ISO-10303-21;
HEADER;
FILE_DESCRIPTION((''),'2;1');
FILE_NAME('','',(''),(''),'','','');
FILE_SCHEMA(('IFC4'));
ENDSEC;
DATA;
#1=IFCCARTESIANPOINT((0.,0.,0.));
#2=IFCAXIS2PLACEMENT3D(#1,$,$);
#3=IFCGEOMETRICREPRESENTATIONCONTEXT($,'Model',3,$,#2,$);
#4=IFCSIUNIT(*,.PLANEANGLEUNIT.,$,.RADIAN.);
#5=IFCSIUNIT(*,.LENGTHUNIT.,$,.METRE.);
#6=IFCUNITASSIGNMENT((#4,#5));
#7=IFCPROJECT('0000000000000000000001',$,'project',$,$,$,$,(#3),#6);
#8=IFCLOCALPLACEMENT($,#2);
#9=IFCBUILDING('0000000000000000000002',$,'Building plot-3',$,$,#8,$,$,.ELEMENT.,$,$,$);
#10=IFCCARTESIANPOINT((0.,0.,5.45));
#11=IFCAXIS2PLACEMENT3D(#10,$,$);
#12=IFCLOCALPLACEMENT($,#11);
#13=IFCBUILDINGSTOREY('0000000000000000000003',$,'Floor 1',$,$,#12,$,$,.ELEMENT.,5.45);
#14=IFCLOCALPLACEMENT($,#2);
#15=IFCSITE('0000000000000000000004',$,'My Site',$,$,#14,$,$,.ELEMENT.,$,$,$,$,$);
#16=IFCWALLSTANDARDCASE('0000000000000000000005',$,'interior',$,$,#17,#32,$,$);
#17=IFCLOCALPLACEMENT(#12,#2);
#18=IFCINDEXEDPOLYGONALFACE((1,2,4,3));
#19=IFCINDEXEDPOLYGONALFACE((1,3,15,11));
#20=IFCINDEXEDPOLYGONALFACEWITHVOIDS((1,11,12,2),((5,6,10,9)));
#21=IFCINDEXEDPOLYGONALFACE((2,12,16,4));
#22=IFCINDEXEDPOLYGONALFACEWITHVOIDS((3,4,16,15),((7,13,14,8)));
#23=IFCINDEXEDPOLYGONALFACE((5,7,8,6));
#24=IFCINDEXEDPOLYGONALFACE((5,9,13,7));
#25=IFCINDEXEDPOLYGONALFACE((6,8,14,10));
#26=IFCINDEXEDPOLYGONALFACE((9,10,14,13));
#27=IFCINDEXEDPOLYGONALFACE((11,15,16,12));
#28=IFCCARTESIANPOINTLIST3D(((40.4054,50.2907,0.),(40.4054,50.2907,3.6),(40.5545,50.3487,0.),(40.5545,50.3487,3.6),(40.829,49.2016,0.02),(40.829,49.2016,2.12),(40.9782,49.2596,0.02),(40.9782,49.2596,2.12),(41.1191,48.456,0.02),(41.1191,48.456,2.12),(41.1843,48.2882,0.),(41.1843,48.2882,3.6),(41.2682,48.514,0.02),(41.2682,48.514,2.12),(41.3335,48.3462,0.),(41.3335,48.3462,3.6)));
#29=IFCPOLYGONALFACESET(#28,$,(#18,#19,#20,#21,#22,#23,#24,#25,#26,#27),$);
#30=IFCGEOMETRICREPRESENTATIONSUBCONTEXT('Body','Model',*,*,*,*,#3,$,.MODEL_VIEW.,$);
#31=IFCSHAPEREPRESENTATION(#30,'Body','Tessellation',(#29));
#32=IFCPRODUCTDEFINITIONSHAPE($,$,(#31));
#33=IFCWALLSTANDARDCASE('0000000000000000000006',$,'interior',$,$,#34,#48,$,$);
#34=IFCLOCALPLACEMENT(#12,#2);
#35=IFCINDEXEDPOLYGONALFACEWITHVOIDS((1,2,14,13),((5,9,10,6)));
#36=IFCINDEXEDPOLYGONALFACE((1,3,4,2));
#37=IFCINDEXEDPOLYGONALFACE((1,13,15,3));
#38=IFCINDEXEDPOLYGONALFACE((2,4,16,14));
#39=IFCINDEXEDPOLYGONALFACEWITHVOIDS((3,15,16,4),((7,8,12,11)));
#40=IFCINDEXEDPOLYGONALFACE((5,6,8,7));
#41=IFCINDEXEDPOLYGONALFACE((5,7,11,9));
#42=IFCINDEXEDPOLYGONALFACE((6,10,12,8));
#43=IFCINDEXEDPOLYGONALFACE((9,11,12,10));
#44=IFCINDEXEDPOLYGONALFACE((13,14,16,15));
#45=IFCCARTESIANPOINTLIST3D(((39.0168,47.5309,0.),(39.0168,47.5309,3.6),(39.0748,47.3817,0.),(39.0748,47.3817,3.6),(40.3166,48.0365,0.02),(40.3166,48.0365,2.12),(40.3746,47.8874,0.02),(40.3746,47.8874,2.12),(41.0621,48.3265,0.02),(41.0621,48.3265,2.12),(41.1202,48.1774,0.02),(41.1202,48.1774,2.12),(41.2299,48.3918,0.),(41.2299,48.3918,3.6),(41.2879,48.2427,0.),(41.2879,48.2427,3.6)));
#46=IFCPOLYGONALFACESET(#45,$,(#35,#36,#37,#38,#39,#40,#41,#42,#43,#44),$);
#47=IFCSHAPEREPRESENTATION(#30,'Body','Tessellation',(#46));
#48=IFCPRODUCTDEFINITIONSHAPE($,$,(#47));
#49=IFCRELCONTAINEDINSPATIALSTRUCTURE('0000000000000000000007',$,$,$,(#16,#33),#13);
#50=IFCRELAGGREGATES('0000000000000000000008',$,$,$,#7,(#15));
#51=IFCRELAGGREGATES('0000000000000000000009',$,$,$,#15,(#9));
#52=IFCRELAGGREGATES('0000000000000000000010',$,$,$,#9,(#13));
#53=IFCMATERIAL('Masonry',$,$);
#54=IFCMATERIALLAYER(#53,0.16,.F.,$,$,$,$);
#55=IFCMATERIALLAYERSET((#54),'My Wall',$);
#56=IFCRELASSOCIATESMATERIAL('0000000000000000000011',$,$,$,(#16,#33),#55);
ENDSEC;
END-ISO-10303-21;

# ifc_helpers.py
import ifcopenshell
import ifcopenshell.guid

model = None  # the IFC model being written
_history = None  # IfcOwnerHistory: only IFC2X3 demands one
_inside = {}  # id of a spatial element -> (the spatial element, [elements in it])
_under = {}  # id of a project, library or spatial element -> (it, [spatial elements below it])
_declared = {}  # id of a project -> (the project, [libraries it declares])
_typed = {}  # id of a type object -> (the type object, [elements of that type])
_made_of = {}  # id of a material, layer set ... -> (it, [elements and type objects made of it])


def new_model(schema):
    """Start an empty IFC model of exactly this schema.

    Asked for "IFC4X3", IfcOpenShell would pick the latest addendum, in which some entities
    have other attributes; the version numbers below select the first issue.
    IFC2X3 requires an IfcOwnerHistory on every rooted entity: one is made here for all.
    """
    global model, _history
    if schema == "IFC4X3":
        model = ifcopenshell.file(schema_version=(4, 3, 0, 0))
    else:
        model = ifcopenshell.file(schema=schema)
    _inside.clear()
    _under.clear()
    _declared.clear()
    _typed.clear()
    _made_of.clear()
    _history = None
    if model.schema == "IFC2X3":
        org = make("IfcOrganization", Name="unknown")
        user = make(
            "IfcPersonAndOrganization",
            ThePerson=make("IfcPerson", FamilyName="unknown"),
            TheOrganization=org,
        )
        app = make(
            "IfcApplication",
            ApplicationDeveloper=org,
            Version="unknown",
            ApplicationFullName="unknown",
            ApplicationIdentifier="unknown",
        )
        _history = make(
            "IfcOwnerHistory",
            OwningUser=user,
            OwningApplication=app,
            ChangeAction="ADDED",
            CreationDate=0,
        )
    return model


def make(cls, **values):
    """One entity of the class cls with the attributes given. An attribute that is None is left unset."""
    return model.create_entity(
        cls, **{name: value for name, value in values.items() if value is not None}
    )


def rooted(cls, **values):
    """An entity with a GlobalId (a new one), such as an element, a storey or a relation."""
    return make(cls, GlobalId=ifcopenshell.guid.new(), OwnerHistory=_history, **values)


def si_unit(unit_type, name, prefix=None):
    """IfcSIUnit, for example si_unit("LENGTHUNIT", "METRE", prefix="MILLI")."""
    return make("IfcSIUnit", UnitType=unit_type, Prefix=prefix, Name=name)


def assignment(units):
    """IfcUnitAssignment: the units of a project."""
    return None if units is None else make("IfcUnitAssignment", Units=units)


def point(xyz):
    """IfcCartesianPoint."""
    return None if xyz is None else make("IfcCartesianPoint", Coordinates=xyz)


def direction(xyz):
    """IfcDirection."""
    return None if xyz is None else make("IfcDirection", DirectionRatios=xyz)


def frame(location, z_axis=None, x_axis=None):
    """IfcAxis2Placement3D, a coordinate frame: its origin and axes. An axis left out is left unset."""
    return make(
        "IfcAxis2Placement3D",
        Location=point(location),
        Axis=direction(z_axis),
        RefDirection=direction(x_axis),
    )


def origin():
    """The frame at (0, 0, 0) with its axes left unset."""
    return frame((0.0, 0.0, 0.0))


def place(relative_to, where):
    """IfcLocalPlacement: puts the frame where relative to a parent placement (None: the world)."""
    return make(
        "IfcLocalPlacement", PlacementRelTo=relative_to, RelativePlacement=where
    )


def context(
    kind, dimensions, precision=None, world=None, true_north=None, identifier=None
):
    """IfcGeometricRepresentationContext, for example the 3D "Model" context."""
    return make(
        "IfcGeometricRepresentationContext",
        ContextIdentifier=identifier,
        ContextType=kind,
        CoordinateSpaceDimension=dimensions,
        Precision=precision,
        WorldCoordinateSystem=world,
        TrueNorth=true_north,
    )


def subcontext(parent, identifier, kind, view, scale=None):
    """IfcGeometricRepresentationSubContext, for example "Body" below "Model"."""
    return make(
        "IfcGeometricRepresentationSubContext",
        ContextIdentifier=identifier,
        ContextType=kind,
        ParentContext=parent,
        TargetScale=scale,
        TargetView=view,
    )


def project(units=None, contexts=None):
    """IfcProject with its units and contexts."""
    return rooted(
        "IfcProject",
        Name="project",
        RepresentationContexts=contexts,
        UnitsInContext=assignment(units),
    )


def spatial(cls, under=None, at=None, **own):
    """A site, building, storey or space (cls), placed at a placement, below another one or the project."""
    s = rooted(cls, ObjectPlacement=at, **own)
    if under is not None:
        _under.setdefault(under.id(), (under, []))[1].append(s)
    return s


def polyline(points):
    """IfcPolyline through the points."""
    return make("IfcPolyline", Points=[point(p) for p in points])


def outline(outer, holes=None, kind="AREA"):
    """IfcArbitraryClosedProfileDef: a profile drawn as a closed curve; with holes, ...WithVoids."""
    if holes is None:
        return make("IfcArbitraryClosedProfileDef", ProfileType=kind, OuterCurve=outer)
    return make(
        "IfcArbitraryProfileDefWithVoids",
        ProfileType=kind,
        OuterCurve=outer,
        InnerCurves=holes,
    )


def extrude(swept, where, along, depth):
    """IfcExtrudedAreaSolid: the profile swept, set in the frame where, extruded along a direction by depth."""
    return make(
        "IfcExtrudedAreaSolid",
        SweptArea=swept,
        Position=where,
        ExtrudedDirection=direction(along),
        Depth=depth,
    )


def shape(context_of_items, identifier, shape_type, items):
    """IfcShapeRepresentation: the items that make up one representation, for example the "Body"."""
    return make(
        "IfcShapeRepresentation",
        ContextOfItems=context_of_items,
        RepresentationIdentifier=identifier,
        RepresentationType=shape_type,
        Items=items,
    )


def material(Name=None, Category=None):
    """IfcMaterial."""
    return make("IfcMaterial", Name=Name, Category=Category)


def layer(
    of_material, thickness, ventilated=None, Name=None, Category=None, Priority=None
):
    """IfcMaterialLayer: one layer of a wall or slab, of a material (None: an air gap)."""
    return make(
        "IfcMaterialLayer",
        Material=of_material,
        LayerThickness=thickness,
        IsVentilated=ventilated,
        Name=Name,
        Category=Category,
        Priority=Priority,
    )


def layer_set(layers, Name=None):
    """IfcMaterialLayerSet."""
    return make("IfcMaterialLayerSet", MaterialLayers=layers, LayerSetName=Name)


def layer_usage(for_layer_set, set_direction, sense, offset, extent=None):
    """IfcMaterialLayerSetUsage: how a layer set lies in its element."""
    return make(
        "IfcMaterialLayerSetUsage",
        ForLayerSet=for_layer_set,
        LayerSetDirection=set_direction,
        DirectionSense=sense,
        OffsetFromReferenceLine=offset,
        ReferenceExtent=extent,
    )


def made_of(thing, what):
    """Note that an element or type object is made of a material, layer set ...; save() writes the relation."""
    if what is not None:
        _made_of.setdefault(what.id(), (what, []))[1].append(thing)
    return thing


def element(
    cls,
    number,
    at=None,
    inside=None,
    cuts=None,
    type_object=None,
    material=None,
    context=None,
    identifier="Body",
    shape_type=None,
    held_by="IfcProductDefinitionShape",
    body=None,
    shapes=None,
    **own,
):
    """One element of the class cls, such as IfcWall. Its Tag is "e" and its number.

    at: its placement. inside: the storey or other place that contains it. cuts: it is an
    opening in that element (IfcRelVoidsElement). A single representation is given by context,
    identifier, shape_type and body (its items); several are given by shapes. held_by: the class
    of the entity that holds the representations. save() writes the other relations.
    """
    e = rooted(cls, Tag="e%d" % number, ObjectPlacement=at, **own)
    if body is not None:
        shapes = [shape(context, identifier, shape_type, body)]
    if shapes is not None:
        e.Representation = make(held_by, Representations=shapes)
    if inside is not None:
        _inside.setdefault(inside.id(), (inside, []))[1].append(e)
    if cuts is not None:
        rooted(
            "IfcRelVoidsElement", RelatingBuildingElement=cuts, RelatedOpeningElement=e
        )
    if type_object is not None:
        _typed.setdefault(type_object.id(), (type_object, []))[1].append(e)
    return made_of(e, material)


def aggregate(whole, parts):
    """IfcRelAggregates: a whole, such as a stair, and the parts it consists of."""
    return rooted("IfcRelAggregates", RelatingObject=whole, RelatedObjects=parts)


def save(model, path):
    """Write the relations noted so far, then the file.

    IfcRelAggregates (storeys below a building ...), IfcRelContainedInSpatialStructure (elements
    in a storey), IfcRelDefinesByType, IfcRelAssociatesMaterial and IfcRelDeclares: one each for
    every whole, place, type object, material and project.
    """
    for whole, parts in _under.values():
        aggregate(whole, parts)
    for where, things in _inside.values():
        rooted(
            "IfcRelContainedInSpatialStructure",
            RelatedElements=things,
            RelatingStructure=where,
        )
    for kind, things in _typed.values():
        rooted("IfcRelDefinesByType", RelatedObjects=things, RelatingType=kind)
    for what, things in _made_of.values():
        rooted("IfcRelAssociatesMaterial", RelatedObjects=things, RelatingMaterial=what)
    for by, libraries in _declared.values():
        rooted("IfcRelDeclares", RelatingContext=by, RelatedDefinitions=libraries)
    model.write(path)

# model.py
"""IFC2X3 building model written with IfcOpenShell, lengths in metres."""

from ifc_helpers import new_model, si_unit, frame, origin, place, context, subcontext, project, spatial, polyline, outline, extrude, material, layer, layer_set, layer_usage, element, save


model = new_model("IFC2X3")

# Units and contexts
model_context = context("Model", 3, world=origin())
body_context = subcontext(model_context, "Body", "Model", "MODEL_VIEW")
ifc_project = project(units=[si_unit("PLANEANGLEUNIT", "RADIAN"), si_unit("LENGTHUNIT", "METRE")], contexts=[model_context])

# Site, building, storey
site_placement = place(None, origin())
site = spatial("IfcSite", under=ifc_project, at=site_placement, Name="My Site", CompositionType="ELEMENT")
building_placement = place(None, origin())
building = spatial("IfcBuilding", under=site, at=building_placement, Name="Building plot-3", CompositionType="ELEMENT")
storey_placement = place(None, frame((0.0, 0.0, 5.45)))
storey = spatial("IfcBuildingStorey", under=building, at=storey_placement, Name="Floor 1", CompositionType="ELEMENT", Elevation=5.45)

# Walls, openings
ifc_material_1 = material(Name="Masonry")
ifc_layer_1 = layer(ifc_material_1, 0.16, ventilated=False)
ifc_layer_set_1 = layer_set([ifc_layer_1], Name="My Wall")
ifc_layer_usage_1 = layer_usage(ifc_layer_set_1, "AXIS2", "NEGATIVE", 0.08)
wall_1_placement = place(storey_placement, origin())
wall_1 = element("IfcWallStandardCase", 1, at=wall_1_placement, inside=storey, material=ifc_layer_usage_1, Name="interior", context=body_context, shape_type="SweptSolid", body=[
    extrude(outline(polyline([(41.1843, 48.2882), (41.3335, 48.3462), (40.5545, 50.3487), (40.4054, 50.2907), (41.1843, 48.2882)])), origin(), (0.0, 0.0, 1.0), 3.6),
])
opening_1_placement = place(storey_placement, frame((0.0, 0.0, 0.02)))
element("IfcOpeningElement", 2, at=opening_1_placement, cuts=wall_1, ObjectType="Opening", context=body_context, shape_type="SweptSolid", body=[
    extrude(outline(polyline([(41.2682, 48.514), (40.9782, 49.2596), (40.829, 49.2016), (41.1191, 48.456), (41.2682, 48.514)])), origin(), (0.0, 0.0, 1.0), 2.1),
])
wall_2_placement = place(storey_placement, origin())
wall_2 = element("IfcWallStandardCase", 3, at=wall_2_placement, inside=storey, material=ifc_layer_usage_1, Name="interior", context=body_context, shape_type="SweptSolid", body=[
    extrude(outline(polyline([(39.0168, 47.5309), (39.0748, 47.3817), (41.2879, 48.2427), (41.2299, 48.3918), (39.0168, 47.5309)])), origin(), (0.0, 0.0, 1.0), 3.6),
])
opening_2_placement = place(storey_placement, frame((0.0, 0.0, 0.02)))
element("IfcOpeningElement", 4, at=opening_2_placement, cuts=wall_2, ObjectType="Opening", context=body_context, shape_type="SweptSolid", body=[
    extrude(outline(polyline([(40.3746, 47.8874), (41.1202, 48.1774), (41.0621, 48.3265), (40.3166, 48.0365), (40.3746, 47.8874)])), origin(), (0.0, 0.0, 1.0), 2.1),
])

save(model, "model.ifc")
